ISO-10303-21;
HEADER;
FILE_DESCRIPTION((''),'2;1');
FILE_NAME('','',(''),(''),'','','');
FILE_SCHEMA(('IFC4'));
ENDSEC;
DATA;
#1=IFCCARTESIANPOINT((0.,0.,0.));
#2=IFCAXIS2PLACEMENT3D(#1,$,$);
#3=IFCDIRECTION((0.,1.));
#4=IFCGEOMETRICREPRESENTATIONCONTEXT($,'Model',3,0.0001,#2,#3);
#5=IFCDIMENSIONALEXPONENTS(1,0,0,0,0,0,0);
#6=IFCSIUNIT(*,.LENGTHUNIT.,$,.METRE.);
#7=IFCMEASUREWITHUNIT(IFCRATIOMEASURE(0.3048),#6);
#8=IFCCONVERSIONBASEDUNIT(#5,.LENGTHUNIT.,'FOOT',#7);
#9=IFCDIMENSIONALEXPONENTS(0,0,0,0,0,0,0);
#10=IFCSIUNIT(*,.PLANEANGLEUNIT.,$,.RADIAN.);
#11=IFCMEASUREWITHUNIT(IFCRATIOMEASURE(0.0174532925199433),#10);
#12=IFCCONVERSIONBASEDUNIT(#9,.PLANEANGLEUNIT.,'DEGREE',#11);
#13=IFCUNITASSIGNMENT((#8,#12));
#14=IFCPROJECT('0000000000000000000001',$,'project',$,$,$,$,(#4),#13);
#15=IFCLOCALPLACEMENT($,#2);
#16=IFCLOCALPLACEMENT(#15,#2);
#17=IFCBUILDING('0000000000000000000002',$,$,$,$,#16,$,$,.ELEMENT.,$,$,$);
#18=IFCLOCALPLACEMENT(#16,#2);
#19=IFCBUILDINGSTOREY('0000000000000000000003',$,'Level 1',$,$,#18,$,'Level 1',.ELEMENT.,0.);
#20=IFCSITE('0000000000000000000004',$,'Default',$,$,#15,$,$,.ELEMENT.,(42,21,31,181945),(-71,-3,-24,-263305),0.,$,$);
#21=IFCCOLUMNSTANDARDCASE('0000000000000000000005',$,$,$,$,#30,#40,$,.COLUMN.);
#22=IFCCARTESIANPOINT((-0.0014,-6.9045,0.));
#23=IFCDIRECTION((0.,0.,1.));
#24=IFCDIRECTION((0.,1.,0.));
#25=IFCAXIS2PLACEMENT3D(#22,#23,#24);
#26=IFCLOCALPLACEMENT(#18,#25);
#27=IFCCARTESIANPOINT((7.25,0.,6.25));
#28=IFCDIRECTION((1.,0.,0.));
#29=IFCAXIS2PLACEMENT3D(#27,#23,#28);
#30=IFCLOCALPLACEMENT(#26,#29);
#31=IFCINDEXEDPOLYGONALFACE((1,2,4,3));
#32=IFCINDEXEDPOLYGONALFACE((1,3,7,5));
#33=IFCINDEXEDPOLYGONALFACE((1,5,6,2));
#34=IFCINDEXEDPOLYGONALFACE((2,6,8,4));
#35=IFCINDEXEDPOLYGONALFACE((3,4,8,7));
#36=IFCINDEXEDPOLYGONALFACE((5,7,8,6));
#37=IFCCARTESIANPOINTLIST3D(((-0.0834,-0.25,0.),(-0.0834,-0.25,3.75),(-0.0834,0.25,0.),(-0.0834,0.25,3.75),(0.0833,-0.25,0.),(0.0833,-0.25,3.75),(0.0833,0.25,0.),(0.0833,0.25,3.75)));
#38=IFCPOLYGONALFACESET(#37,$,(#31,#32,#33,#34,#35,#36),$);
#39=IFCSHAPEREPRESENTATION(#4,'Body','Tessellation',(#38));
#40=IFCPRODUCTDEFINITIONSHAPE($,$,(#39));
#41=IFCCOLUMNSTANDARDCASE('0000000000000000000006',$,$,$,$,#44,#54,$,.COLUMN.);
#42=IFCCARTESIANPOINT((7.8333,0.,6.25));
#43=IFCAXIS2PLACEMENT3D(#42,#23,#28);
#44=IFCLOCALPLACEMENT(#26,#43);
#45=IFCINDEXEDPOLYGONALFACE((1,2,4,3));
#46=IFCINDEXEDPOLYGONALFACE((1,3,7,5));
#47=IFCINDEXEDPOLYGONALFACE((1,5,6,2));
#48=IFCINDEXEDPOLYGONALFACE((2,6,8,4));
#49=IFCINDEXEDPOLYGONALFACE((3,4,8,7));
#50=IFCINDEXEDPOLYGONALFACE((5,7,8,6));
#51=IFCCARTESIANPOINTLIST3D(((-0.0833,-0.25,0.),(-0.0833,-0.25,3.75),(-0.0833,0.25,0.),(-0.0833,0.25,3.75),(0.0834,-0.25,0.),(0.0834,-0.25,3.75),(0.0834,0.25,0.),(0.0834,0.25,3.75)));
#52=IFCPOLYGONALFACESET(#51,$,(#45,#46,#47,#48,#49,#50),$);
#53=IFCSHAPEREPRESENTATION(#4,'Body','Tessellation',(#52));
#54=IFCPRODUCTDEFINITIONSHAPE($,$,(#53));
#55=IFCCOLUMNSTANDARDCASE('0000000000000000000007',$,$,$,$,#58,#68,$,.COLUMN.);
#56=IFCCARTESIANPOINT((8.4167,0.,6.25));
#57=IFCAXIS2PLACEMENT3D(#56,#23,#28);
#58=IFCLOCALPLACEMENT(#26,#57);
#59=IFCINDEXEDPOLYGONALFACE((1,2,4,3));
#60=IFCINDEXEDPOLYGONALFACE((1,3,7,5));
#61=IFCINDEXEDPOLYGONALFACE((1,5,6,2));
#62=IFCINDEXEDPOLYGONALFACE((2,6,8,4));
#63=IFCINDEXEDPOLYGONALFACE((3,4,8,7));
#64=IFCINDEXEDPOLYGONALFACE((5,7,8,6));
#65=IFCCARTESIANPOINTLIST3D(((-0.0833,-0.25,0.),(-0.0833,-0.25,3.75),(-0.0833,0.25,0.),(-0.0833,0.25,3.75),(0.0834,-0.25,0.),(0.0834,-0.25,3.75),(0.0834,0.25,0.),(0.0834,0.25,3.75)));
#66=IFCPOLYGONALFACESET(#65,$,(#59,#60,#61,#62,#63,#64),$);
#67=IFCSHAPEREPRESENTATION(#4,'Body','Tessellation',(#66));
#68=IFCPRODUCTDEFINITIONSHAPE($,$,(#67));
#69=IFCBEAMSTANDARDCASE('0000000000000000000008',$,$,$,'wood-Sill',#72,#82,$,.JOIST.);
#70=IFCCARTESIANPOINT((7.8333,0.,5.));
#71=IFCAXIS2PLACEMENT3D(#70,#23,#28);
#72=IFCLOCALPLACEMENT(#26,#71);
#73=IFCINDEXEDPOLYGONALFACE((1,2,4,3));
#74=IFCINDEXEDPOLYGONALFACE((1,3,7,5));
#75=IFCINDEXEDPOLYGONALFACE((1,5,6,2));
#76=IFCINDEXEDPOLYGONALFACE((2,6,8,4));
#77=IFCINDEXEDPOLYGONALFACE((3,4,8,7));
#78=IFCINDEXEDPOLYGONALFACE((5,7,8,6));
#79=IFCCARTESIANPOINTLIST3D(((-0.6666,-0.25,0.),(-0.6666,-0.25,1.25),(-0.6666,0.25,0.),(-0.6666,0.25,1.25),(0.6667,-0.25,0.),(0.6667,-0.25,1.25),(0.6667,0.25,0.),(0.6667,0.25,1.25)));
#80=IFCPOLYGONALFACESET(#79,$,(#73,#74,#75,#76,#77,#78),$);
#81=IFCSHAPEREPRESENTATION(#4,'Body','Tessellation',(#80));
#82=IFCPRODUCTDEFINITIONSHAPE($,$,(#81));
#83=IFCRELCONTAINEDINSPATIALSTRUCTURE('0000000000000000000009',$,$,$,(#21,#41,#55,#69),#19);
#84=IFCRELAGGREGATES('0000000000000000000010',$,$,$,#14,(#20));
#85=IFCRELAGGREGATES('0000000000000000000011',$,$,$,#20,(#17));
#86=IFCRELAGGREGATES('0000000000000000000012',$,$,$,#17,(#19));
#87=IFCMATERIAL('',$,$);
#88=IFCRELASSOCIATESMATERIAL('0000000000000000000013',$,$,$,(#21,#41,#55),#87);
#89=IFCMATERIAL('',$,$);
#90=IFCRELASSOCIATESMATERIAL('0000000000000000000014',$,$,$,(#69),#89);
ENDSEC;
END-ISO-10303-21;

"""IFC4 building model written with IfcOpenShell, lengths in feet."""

from ifc_helpers import new_model, entity, si_unit, converted_unit, direction, frame, origin, place, context, project, spatial, rectangle, extrude, material, element, save


model = new_model("IFC4")

# Units and contexts
model_context = context("Model", 3, precision=0.0001, world=origin(), true_north=direction((0.0, 1.0)))
ifc_project = project(units=[converted_unit("LENGTHUNIT", "FOOT", entity("IfcRatioMeasure", 0.3048), si_unit("LENGTHUNIT", "METRE"), dimensions=[1, 0, 0, 0, 0, 0, 0]), converted_unit("PLANEANGLEUNIT", "DEGREE", entity("IfcRatioMeasure", 0.0174532925199433), si_unit("PLANEANGLEUNIT", "RADIAN"), dimensions=[0, 0, 0, 0, 0, 0, 0])], contexts=[model_context])

# Site, building, storey
site_placement = place(None, origin())
site = spatial("IfcSite", under=ifc_project, at=site_placement, Name="Default", CompositionType="ELEMENT", RefLatitude=(42, 21, 31, 181945), RefLongitude=(-71, -3, -24, -263305), RefElevation=0.0)
building_placement = place(site_placement, origin())
building = spatial("IfcBuilding", under=site, at=building_placement, CompositionType="ELEMENT")
storey_placement = place(building_placement, origin())
storey = spatial("IfcBuildingStorey", under=building, at=storey_placement, Name="Level 1", LongName="Level 1", CompositionType="ELEMENT", Elevation=0.0)

# Columns
placement_1 = place(storey_placement, frame((-0.0014, -6.9045, 0.0), z_axis=(0.0, 0.0, 1.0), x_axis=(0.0, 1.0, 0.0)))
ifc_material_1 = material(Name="")
for number, where, z_axis, x_axis in (
    (1, (7.25, 0.0, 6.25), (0.0, 0.0, 1.0), (1.0, 0.0, 0.0)),
    (2, (7.8333, 0.0, 6.25), (0.0, 0.0, 1.0), (1.0, 0.0, 0.0)),
    (3, (8.4167, 0.0, 6.25), (0.0, 0.0, 1.0), (1.0, 0.0, 0.0)),
):
    element("IfcColumnStandardCase", number, at=place(placement_1, frame(where, z_axis=z_axis, x_axis=x_axis)), inside=storey, material=ifc_material_1, PredefinedType="COLUMN", context=model_context, shape_type="SweptSolid", body=[
        extrude(rectangle(XDim=0.1667, YDim=0.5), origin(), (0.0, 0.0, 1.0), 3.75),
    ])

# Beam
ifc_material_2 = material(Name="")
for number, where, z_axis, x_axis in (
    (4, (7.8333, 0.0, 5.0), (0.0, 0.0, 1.0), (1.0, 0.0, 0.0)),
):
    element("IfcBeamStandardCase", number, at=place(placement_1, frame(where, z_axis=z_axis, x_axis=x_axis)), inside=storey, material=ifc_material_2, ObjectType="wood-Sill", PredefinedType="JOIST", context=model_context, shape_type="SweptSolid", body=[
        extrude(rectangle(XDim=1.3333, YDim=0.5), origin(), (0.0, 0.0, 1.0), 1.25),
    ])

save(model, "model.ifc")
